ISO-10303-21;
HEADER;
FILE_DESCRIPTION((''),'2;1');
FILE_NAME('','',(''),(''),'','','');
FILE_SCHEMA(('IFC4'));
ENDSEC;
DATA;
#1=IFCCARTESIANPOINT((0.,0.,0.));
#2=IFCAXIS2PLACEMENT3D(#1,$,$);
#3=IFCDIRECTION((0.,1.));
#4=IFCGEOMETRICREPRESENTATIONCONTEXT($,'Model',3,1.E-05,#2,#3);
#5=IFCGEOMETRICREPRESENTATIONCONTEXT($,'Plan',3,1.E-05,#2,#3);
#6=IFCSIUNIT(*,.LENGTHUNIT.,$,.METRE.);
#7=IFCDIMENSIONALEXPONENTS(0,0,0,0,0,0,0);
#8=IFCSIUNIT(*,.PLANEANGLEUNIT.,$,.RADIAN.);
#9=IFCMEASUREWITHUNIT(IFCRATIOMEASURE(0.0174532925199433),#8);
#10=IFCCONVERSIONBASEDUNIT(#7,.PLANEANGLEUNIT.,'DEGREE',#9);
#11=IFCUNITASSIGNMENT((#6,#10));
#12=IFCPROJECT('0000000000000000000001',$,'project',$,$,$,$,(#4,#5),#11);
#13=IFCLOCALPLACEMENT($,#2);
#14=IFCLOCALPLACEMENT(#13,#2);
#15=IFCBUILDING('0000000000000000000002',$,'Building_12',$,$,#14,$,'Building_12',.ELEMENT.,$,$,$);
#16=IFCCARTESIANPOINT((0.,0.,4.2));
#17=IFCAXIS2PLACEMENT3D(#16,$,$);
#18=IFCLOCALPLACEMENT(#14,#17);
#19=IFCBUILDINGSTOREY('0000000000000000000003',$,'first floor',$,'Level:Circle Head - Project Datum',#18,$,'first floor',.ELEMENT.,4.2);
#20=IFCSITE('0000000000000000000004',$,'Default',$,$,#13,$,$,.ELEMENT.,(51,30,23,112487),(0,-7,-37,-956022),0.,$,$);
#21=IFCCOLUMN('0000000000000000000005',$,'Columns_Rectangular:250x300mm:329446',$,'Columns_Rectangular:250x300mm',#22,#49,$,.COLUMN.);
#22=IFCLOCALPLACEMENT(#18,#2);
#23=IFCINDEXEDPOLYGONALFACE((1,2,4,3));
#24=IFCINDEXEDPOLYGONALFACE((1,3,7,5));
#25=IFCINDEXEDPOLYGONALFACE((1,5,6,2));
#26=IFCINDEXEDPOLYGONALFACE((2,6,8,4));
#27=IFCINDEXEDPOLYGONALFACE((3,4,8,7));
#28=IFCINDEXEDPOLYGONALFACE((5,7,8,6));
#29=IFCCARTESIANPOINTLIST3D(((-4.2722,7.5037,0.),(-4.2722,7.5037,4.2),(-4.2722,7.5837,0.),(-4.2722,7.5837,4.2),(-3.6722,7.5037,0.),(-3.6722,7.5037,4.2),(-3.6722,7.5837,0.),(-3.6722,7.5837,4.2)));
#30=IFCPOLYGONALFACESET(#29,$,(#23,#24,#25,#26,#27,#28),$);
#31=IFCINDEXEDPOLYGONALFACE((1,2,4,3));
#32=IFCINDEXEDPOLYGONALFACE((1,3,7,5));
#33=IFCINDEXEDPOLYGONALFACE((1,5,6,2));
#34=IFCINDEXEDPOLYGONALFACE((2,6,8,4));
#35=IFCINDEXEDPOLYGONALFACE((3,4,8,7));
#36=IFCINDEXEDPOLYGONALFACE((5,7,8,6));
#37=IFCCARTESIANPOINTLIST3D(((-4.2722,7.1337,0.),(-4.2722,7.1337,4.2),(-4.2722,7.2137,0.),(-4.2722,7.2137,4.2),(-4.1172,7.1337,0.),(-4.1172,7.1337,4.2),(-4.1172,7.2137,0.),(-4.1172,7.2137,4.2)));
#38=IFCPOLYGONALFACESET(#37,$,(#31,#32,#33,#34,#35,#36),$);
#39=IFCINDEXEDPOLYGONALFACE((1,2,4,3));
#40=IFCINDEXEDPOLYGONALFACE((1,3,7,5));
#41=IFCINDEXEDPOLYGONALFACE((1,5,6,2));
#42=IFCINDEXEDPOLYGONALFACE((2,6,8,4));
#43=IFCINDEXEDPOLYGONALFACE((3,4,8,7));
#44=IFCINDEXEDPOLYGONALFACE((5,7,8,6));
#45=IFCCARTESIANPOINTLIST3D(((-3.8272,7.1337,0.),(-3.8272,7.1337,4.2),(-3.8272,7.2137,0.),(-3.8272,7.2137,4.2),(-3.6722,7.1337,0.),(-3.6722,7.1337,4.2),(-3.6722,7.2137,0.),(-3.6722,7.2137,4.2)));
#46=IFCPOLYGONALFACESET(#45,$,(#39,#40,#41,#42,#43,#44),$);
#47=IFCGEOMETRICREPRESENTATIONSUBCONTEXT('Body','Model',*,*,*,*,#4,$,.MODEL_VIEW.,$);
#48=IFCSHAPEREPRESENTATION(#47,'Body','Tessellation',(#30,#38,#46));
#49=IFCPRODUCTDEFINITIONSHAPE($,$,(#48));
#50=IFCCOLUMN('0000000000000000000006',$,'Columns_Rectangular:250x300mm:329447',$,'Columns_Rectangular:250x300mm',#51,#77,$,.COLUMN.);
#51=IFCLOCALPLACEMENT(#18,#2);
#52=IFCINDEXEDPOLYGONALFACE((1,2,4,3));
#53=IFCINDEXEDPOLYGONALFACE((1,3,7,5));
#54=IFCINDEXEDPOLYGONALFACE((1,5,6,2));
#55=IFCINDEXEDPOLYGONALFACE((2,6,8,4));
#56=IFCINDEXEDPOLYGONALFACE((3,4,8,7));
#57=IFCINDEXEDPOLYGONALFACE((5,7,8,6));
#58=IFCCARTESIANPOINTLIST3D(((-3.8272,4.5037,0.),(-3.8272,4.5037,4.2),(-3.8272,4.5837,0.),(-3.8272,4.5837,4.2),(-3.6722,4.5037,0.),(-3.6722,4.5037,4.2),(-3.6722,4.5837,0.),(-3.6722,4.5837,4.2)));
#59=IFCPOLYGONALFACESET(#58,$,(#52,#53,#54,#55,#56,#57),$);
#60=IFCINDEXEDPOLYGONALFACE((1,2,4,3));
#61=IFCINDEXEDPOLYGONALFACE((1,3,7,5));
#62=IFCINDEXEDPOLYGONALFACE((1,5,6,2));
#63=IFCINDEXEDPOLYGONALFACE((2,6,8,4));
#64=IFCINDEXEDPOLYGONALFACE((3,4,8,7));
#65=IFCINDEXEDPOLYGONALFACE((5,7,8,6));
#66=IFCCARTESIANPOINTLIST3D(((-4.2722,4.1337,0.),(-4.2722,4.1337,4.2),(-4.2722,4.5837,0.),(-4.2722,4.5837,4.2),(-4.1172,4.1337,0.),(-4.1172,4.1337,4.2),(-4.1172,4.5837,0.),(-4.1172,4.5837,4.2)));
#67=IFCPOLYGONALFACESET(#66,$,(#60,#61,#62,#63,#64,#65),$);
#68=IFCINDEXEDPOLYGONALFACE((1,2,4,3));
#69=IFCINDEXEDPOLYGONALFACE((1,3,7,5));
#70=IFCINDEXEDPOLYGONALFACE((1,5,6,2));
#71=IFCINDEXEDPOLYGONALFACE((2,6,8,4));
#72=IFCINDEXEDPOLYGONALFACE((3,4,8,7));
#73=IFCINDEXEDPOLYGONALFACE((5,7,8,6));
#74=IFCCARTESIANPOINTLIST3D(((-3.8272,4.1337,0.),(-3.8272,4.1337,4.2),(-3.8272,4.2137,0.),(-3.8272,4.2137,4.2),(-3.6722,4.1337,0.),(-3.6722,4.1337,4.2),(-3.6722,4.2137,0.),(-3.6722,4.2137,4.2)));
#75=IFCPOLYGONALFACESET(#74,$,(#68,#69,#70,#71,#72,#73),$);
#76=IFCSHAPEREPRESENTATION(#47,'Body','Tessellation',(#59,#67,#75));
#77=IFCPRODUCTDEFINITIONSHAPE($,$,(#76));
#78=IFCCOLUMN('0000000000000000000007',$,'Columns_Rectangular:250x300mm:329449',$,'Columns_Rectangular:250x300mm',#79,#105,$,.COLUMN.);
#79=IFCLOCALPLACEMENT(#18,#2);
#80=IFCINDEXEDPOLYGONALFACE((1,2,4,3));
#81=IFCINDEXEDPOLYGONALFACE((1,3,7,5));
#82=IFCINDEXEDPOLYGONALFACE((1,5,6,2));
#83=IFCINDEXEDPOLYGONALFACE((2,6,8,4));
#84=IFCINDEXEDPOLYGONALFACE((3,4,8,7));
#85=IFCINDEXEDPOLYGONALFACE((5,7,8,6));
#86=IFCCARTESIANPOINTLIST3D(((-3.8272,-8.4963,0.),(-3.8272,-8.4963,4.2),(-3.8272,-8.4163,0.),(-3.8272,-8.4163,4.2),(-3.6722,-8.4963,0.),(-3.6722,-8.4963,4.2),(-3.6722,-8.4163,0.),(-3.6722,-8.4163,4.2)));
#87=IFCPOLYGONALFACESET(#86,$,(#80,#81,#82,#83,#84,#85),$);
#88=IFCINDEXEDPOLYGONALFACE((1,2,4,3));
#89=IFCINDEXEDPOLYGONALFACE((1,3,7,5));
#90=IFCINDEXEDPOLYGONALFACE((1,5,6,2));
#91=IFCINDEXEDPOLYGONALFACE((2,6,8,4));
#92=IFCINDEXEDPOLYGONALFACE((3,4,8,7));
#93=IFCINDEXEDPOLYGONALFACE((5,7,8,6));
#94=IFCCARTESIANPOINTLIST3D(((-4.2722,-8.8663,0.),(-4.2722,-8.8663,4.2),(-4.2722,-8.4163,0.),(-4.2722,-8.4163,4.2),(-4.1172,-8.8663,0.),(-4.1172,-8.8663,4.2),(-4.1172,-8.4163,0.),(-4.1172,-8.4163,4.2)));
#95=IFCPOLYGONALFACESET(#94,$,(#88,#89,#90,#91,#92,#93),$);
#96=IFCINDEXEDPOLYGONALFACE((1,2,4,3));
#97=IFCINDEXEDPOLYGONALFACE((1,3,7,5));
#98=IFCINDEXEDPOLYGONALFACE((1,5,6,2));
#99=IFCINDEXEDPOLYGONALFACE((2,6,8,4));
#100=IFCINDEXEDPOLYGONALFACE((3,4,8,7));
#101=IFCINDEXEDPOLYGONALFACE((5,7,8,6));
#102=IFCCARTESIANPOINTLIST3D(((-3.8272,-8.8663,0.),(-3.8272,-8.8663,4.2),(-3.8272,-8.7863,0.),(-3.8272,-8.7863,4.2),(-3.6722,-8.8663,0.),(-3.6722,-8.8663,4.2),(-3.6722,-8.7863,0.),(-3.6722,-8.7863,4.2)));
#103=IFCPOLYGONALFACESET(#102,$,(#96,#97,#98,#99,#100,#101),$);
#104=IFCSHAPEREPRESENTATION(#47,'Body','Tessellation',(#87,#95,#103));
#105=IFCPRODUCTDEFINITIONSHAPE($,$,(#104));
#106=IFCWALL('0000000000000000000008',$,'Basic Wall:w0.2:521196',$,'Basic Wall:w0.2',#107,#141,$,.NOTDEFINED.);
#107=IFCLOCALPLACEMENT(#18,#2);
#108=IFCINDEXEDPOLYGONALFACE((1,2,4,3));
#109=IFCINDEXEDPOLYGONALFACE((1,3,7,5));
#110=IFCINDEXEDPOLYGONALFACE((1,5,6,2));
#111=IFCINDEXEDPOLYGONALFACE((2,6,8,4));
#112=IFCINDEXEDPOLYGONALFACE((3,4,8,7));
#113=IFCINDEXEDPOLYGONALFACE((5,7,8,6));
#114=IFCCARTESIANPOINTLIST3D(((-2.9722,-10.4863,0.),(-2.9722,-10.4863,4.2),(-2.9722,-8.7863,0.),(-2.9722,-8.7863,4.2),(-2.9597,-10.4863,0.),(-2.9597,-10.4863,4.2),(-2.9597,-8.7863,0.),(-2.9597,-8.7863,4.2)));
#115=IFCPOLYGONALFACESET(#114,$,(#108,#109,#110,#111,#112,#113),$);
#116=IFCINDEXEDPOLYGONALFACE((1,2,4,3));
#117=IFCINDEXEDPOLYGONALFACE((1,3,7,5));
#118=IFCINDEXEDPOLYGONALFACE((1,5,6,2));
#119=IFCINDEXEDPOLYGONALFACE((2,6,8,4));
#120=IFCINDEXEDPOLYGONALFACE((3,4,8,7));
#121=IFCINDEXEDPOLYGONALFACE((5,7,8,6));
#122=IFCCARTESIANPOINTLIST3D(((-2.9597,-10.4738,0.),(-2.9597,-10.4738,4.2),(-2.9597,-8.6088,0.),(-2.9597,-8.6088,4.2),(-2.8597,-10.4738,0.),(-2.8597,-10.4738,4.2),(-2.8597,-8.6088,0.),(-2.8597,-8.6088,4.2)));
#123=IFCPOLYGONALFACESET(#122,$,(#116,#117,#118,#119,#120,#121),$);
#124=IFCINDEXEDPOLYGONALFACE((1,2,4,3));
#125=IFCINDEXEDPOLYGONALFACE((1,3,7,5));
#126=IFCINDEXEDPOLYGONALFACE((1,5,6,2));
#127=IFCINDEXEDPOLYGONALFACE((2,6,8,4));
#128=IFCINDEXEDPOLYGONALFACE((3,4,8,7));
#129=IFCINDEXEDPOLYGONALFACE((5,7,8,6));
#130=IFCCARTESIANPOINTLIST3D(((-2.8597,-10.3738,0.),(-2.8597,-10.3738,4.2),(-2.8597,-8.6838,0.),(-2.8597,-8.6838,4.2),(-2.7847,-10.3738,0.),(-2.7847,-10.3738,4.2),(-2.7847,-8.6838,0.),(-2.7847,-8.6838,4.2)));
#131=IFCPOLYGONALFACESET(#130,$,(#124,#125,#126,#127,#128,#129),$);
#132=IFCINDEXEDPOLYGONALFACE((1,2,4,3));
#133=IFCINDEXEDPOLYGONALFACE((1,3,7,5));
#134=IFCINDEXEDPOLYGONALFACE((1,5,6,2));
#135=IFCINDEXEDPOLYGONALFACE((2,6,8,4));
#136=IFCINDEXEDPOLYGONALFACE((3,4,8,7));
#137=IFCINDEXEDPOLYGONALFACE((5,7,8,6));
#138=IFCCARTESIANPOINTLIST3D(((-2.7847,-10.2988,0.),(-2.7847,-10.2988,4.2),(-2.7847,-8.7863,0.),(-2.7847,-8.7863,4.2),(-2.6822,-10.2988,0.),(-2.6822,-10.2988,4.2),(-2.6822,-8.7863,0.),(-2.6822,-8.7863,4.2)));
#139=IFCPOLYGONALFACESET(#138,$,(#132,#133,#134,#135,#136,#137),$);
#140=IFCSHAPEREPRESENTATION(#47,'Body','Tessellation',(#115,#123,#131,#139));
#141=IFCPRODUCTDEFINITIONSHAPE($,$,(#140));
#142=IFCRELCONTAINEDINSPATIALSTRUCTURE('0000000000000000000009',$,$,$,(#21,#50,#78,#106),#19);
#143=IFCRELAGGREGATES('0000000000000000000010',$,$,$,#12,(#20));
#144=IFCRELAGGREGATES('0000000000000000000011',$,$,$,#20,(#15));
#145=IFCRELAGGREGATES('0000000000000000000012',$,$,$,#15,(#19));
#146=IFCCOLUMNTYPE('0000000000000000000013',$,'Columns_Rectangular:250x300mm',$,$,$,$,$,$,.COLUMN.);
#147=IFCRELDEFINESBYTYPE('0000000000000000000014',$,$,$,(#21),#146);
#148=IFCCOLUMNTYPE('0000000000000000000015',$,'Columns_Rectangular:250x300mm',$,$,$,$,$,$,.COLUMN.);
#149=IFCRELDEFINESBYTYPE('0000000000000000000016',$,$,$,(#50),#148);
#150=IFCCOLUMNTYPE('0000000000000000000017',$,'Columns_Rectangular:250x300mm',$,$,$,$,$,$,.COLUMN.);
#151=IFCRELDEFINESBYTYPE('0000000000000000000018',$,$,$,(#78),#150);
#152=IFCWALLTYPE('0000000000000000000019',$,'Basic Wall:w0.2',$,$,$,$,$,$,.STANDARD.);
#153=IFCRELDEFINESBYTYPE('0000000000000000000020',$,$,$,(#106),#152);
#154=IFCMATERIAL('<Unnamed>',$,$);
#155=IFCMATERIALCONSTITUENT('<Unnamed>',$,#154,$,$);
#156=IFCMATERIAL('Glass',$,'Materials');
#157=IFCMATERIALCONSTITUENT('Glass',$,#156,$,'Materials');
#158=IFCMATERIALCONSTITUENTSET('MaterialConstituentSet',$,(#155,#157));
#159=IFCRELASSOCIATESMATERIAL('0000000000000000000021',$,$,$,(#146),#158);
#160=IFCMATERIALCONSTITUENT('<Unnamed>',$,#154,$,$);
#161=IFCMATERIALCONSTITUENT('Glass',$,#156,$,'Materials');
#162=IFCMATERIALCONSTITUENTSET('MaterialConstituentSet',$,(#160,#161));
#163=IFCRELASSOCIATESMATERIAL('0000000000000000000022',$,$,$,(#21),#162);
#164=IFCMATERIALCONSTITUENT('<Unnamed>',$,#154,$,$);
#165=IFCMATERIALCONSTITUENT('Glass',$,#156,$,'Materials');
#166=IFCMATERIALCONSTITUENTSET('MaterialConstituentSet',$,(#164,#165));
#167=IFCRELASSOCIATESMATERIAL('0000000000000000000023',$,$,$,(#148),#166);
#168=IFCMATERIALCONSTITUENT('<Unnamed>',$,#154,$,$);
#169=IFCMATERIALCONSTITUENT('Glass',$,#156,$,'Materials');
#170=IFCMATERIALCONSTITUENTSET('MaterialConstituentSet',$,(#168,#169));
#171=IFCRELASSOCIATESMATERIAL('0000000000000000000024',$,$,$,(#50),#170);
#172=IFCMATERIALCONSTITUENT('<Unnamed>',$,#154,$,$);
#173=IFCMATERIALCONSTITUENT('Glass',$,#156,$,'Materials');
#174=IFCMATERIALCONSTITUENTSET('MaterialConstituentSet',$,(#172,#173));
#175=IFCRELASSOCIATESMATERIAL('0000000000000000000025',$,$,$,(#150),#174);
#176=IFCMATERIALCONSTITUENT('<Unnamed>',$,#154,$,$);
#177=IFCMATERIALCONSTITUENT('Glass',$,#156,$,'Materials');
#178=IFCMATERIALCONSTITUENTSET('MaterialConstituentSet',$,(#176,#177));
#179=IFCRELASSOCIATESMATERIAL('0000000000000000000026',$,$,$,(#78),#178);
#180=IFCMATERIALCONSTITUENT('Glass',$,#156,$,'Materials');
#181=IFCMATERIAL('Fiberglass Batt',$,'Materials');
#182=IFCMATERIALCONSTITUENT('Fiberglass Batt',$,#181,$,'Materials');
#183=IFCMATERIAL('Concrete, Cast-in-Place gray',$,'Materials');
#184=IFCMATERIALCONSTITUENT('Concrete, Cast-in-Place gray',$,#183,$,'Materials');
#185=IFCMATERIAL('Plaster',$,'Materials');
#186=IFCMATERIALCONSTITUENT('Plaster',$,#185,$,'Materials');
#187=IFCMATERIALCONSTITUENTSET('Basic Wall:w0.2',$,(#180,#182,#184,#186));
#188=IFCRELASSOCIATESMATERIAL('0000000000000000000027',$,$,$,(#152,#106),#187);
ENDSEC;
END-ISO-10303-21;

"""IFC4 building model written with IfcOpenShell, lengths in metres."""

from ifc_helpers import new_model, entity, si_unit, converted_unit, direction, frame, origin, place, context, subcontext, project, spatial, indexed_curve, outline, extrude, source, transform, mapped, material, constituent, constituent_set, type_object, type_shapes, element, save


model = new_model("IFC4")

# Units and contexts
model_context = context("Model", 3, precision=1e-05, world=origin(), true_north=direction((0.0, 1.0)))
plan_context = context("Plan", 3, precision=1e-05, world=origin(), true_north=direction((0.0, 1.0)))
body_context = subcontext(model_context, "Body", "Model", "MODEL_VIEW")
ifc_project = project(units=[si_unit("LENGTHUNIT", "METRE"), converted_unit("PLANEANGLEUNIT", "DEGREE", entity("IfcRatioMeasure", 0.0174532925199433), si_unit("PLANEANGLEUNIT", "RADIAN"), dimensions=[0, 0, 0, 0, 0, 0, 0])], contexts=[model_context, plan_context])

# Site, building, storey
site_placement = place(None, origin())
site = spatial("IfcSite", under=ifc_project, at=site_placement, Name="Default", CompositionType="ELEMENT", RefLatitude=(51, 30, 23, 112487), RefLongitude=(0, -7, -37, -956022), RefElevation=0.0)
building_placement = place(site_placement, origin())
building = spatial("IfcBuilding", under=site, at=building_placement, Name="Building_12", LongName="Building_12", CompositionType="ELEMENT")
storey_placement = place(building_placement, frame((0.0, 0.0, 4.2)))
storey = spatial("IfcBuildingStorey", under=building, at=storey_placement, Name="first floor", ObjectType="Level:Circle Head - Project Datum", LongName="first floor", CompositionType="ELEMENT", Elevation=4.2)

# Columns
ifc_material_1 = material(Name="<Unnamed>")
ifc_material_2 = material(Name="Plaster", Category="Materials")
ifc_constituent_1 = constituent(ifc_material_1, Name="<Unnamed>")
ifc_material_3 = material(Name="Glass", Category="Materials")
ifc_constituent_2 = constituent(ifc_material_3, Name="Glass", Category="Materials")
ifc_constituent_set_1 = constituent_set(constituents=[ifc_constituent_1, ifc_constituent_2], Name="MaterialConstituentSet")
ifc_constituent_3 = constituent(ifc_material_1, Name="<Unnamed>")
ifc_constituent_4 = constituent(ifc_material_3, Name="Glass", Category="Materials")
ifc_constituent_set_2 = constituent_set(constituents=[ifc_constituent_3, ifc_constituent_4], Name="MaterialConstituentSet")
column_type_1 = type_object("IfcColumnType", Name="Columns_Rectangular:250x300mm", PredefinedType="COLUMN", material=ifc_constituent_set_2)
shared_shape_1 = source(origin(), body_context, "Body", "SweptSolid", [
    extrude(outline(indexed_curve([(-0.04, -0.3), (0.04, -0.3), (0.04, 0.3), (-0.04, 0.3), (-0.04, -0.3)], self_intersect=False)), frame((-3.9722, 7.5437, 4.2), z_axis=(0.0, 0.0, 1.0), x_axis=(0.0, -1.0, 0.0)), (0.0, 0.0, 1.0), 4.2),
    extrude(outline(indexed_curve([(-0.04, -0.0775), (0.04, -0.0775), (0.04, 0.0775), (-0.04, 0.0775), (-0.04, -0.0775)], self_intersect=False)), frame((-4.1947, 7.1737, 4.2), z_axis=(0.0, 0.0, 1.0), x_axis=(0.0, -1.0, 0.0)), (0.0, 0.0, 1.0), 4.2),
    extrude(outline(indexed_curve([(-0.04, -0.0775), (0.04, -0.0775), (0.04, 0.0775), (-0.04, 0.0775), (-0.04, -0.0775)], self_intersect=False)), frame((-3.7497, 7.1737, 4.2), z_axis=(0.0, 0.0, 1.0), x_axis=(0.0, -1.0, 0.0)), (0.0, 0.0, 1.0), 4.2),
])
type_shapes(column_type_1, [shared_shape_1])
column_1_placement = place(storey_placement, frame((0.0, 0.0, -4.2)))
element("IfcColumn", 1, at=column_1_placement, inside=storey, type_object=column_type_1, material=ifc_constituent_set_1, Name="Columns_Rectangular:250x300mm:329446", ObjectType="Columns_Rectangular:250x300mm", PredefinedType="COLUMN", context=body_context, shape_type="MappedRepresentation", body=[
    mapped(shared_shape_1, transform((0.0, 0.0, 0.0), scale=1.0)),
])
ifc_constituent_5 = constituent(ifc_material_1, Name="<Unnamed>")
ifc_constituent_6 = constituent(ifc_material_3, Name="Glass", Category="Materials")
ifc_constituent_set_3 = constituent_set(constituents=[ifc_constituent_5, ifc_constituent_6], Name="MaterialConstituentSet")
ifc_constituent_7 = constituent(ifc_material_1, Name="<Unnamed>")
ifc_constituent_8 = constituent(ifc_material_3, Name="Glass", Category="Materials")
ifc_constituent_set_4 = constituent_set(constituents=[ifc_constituent_7, ifc_constituent_8], Name="MaterialConstituentSet")
column_type_2 = type_object("IfcColumnType", Name="Columns_Rectangular:250x300mm", PredefinedType="COLUMN", material=ifc_constituent_set_4)
shared_shape_2 = source(origin(), body_context, "Body", "SweptSolid", [
    extrude(outline(indexed_curve([(-0.04, -0.0775), (0.04, -0.0775), (0.04, 0.0775), (-0.04, 0.0775), (-0.04, -0.0775)], self_intersect=False)), frame((-3.7497, 4.5437, 4.2), z_axis=(0.0, 0.0, 1.0), x_axis=(0.0, -1.0, 0.0)), (0.0, 0.0, 1.0), 4.2),
    extrude(outline(indexed_curve([(-0.225, -0.0775), (0.225, -0.0775), (0.225, 0.0775), (-0.225, 0.0775), (-0.225, -0.0775)], self_intersect=False)), frame((-4.1947, 4.3587, 4.2), z_axis=(0.0, 0.0, 1.0), x_axis=(0.0, -1.0, 0.0)), (0.0, 0.0, 1.0), 4.2),
    extrude(outline(indexed_curve([(-0.04, -0.0775), (0.04, -0.0775), (0.04, 0.0775), (-0.04, 0.0775), (-0.04, -0.0775)], self_intersect=False)), frame((-3.7497, 4.1737, 4.2), z_axis=(0.0, 0.0, 1.0), x_axis=(0.0, -1.0, 0.0)), (0.0, 0.0, 1.0), 4.2),
])
type_shapes(column_type_2, [shared_shape_2])
column_2_placement = place(storey_placement, frame((0.0, 0.0, -4.2)))
element("IfcColumn", 2, at=column_2_placement, inside=storey, type_object=column_type_2, material=ifc_constituent_set_3, Name="Columns_Rectangular:250x300mm:329447", ObjectType="Columns_Rectangular:250x300mm", PredefinedType="COLUMN", context=body_context, shape_type="MappedRepresentation", body=[
    mapped(shared_shape_2, transform((0.0, 0.0, 0.0), scale=1.0)),
])
ifc_constituent_9 = constituent(ifc_material_1, Name="<Unnamed>")
ifc_constituent_10 = constituent(ifc_material_3, Name="Glass", Category="Materials")
ifc_constituent_set_5 = constituent_set(constituents=[ifc_constituent_9, ifc_constituent_10], Name="MaterialConstituentSet")
ifc_constituent_11 = constituent(ifc_material_1, Name="<Unnamed>")
ifc_constituent_12 = constituent(ifc_material_3, Name="Glass", Category="Materials")
ifc_constituent_set_6 = constituent_set(constituents=[ifc_constituent_11, ifc_constituent_12], Name="MaterialConstituentSet")
column_type_3 = type_object("IfcColumnType", Name="Columns_Rectangular:250x300mm", PredefinedType="COLUMN", material=ifc_constituent_set_6)
shared_shape_3 = source(origin(), body_context, "Body", "SweptSolid", [
    extrude(outline(indexed_curve([(-0.04, -0.0775), (0.04, -0.0775), (0.04, 0.0775), (-0.04, 0.0775), (-0.04, -0.0775)], self_intersect=False)), frame((-3.7497, -8.4563, 4.2), z_axis=(0.0, 0.0, 1.0), x_axis=(0.0, -1.0, 0.0)), (0.0, 0.0, 1.0), 4.2),
    extrude(outline(indexed_curve([(-0.225, -0.0775), (0.225, -0.0775), (0.225, 0.0775), (-0.225, 0.0775), (-0.225, -0.0775)], self_intersect=False)), frame((-4.1947, -8.6413, 4.2), z_axis=(0.0, 0.0, 1.0), x_axis=(0.0, -1.0, 0.0)), (0.0, 0.0, 1.0), 4.2),
    extrude(outline(indexed_curve([(-0.04, -0.0775), (0.04, -0.0775), (0.04, 0.0775), (-0.04, 0.0775), (-0.04, -0.0775)], self_intersect=False)), frame((-3.7497, -8.8263, 4.2), z_axis=(0.0, 0.0, 1.0), x_axis=(0.0, -1.0, 0.0)), (0.0, 0.0, 1.0), 4.2),
])
type_shapes(column_type_3, [shared_shape_3])
column_3_placement = place(storey_placement, frame((0.0, 0.0, -4.2)))
element("IfcColumn", 3, at=column_3_placement, inside=storey, type_object=column_type_3, material=ifc_constituent_set_5, Name="Columns_Rectangular:250x300mm:329449", ObjectType="Columns_Rectangular:250x300mm", PredefinedType="COLUMN", context=body_context, shape_type="MappedRepresentation", body=[
    mapped(shared_shape_3, transform((0.0, 0.0, 0.0), scale=1.0)),
])

# Shared definitions
ifc_constituent_13 = constituent(ifc_material_3, Name="Glass", Category="Materials")
ifc_material_4 = material(Name="Fiberglass Batt", Category="Materials")
ifc_constituent_14 = constituent(ifc_material_4, Name="Fiberglass Batt", Category="Materials")
ifc_material_5 = material(Name="Concrete, Cast-in-Place gray", Category="Materials")
ifc_constituent_15 = constituent(ifc_material_5, Name="Concrete, Cast-in-Place gray", Category="Materials")
ifc_constituent_16 = constituent(ifc_material_2, Name="Plaster", Category="Materials")
ifc_constituent_set_7 = constituent_set(constituents=[ifc_constituent_13, ifc_constituent_14, ifc_constituent_15, ifc_constituent_16], Name="Basic Wall:w0.2")
wall_type_1 = type_object("IfcWallType", Name="Basic Wall:w0.2", PredefinedType="STANDARD", material=ifc_constituent_set_7)

# Wall, opening
wall_1_placement = place(storey_placement, frame((-2.8272, -8.7863, 0.0), z_axis=(0.0, 0.0, 1.0), x_axis=(0.0, -1.0, 0.0)))
wall_1 = element("IfcWall", 4, at=wall_1_placement, inside=storey, type_object=wall_type_1, material=ifc_constituent_set_7, Name="Basic Wall:w0.2:521196", ObjectType="Basic Wall:w0.2", PredefinedType="NOTDEFINED", context=body_context, shape_type="SweptSolid", body=[
    extrude(outline(indexed_curve([(-0.0063, -0.85), (0.0062, -0.85), (0.0063, 0.85), (-0.0062, 0.85), (-0.0063, -0.85)], self_intersect=False)), frame((0.85, -0.1388, 0.0), z_axis=(0.0, 0.0, 1.0), x_axis=(0.0, 1.0, 0.0)), (0.0, 0.0, 1.0), 4.2),
    extrude(outline(indexed_curve([(-0.9325, -0.05), (0.9325, -0.05), (0.9325, 0.05), (-0.9325, 0.05), (-0.9325, -0.05)], self_intersect=False)), frame((0.755, -0.0825, 0.0)), (0.0, 0.0, 1.0), 4.2),
    extrude(outline(indexed_curve([(-0.845, -0.0375), (0.845, -0.0375), (0.845, 0.0375), (-0.845, 0.0375), (-0.845, -0.0375)], self_intersect=False)), frame((0.7425, 0.005, 0.0)), (0.0, 0.0, 1.0), 4.2),
    extrude(outline(indexed_curve([(-0.0513, -0.7562), (0.0512, -0.7562), (0.0513, 0.7563), (-0.0512, 0.7563), (-0.0513, -0.7562)], self_intersect=False)), frame((0.7563, 0.0938, 0.0), z_axis=(0.0, 0.0, 1.0), x_axis=(0.0, -1.0, 0.0)), (0.0, 0.0, 1.0), 4.2),
])
opening_1_placement = place(wall_1_placement, origin())
element("IfcOpeningElement", 5, at=opening_1_placement, cuts=wall_1, PredefinedType="OPENING", context=body_context, shape_type="SweptSolid", body=[
    extrude(outline(indexed_curve([(-0.145, -1.055), (0.145, -1.055), (0.145, 1.055), (-0.145, 1.055), (-0.145, -1.055)], self_intersect=False)), frame((1.555, 0.145, 1.055), z_axis=(0.0, 1.0, 0.0), x_axis=(-1.0, 0.0, 0.0)), (0.0, 0.0, 1.0), 0.81),
])

save(model, "model.ifc")
